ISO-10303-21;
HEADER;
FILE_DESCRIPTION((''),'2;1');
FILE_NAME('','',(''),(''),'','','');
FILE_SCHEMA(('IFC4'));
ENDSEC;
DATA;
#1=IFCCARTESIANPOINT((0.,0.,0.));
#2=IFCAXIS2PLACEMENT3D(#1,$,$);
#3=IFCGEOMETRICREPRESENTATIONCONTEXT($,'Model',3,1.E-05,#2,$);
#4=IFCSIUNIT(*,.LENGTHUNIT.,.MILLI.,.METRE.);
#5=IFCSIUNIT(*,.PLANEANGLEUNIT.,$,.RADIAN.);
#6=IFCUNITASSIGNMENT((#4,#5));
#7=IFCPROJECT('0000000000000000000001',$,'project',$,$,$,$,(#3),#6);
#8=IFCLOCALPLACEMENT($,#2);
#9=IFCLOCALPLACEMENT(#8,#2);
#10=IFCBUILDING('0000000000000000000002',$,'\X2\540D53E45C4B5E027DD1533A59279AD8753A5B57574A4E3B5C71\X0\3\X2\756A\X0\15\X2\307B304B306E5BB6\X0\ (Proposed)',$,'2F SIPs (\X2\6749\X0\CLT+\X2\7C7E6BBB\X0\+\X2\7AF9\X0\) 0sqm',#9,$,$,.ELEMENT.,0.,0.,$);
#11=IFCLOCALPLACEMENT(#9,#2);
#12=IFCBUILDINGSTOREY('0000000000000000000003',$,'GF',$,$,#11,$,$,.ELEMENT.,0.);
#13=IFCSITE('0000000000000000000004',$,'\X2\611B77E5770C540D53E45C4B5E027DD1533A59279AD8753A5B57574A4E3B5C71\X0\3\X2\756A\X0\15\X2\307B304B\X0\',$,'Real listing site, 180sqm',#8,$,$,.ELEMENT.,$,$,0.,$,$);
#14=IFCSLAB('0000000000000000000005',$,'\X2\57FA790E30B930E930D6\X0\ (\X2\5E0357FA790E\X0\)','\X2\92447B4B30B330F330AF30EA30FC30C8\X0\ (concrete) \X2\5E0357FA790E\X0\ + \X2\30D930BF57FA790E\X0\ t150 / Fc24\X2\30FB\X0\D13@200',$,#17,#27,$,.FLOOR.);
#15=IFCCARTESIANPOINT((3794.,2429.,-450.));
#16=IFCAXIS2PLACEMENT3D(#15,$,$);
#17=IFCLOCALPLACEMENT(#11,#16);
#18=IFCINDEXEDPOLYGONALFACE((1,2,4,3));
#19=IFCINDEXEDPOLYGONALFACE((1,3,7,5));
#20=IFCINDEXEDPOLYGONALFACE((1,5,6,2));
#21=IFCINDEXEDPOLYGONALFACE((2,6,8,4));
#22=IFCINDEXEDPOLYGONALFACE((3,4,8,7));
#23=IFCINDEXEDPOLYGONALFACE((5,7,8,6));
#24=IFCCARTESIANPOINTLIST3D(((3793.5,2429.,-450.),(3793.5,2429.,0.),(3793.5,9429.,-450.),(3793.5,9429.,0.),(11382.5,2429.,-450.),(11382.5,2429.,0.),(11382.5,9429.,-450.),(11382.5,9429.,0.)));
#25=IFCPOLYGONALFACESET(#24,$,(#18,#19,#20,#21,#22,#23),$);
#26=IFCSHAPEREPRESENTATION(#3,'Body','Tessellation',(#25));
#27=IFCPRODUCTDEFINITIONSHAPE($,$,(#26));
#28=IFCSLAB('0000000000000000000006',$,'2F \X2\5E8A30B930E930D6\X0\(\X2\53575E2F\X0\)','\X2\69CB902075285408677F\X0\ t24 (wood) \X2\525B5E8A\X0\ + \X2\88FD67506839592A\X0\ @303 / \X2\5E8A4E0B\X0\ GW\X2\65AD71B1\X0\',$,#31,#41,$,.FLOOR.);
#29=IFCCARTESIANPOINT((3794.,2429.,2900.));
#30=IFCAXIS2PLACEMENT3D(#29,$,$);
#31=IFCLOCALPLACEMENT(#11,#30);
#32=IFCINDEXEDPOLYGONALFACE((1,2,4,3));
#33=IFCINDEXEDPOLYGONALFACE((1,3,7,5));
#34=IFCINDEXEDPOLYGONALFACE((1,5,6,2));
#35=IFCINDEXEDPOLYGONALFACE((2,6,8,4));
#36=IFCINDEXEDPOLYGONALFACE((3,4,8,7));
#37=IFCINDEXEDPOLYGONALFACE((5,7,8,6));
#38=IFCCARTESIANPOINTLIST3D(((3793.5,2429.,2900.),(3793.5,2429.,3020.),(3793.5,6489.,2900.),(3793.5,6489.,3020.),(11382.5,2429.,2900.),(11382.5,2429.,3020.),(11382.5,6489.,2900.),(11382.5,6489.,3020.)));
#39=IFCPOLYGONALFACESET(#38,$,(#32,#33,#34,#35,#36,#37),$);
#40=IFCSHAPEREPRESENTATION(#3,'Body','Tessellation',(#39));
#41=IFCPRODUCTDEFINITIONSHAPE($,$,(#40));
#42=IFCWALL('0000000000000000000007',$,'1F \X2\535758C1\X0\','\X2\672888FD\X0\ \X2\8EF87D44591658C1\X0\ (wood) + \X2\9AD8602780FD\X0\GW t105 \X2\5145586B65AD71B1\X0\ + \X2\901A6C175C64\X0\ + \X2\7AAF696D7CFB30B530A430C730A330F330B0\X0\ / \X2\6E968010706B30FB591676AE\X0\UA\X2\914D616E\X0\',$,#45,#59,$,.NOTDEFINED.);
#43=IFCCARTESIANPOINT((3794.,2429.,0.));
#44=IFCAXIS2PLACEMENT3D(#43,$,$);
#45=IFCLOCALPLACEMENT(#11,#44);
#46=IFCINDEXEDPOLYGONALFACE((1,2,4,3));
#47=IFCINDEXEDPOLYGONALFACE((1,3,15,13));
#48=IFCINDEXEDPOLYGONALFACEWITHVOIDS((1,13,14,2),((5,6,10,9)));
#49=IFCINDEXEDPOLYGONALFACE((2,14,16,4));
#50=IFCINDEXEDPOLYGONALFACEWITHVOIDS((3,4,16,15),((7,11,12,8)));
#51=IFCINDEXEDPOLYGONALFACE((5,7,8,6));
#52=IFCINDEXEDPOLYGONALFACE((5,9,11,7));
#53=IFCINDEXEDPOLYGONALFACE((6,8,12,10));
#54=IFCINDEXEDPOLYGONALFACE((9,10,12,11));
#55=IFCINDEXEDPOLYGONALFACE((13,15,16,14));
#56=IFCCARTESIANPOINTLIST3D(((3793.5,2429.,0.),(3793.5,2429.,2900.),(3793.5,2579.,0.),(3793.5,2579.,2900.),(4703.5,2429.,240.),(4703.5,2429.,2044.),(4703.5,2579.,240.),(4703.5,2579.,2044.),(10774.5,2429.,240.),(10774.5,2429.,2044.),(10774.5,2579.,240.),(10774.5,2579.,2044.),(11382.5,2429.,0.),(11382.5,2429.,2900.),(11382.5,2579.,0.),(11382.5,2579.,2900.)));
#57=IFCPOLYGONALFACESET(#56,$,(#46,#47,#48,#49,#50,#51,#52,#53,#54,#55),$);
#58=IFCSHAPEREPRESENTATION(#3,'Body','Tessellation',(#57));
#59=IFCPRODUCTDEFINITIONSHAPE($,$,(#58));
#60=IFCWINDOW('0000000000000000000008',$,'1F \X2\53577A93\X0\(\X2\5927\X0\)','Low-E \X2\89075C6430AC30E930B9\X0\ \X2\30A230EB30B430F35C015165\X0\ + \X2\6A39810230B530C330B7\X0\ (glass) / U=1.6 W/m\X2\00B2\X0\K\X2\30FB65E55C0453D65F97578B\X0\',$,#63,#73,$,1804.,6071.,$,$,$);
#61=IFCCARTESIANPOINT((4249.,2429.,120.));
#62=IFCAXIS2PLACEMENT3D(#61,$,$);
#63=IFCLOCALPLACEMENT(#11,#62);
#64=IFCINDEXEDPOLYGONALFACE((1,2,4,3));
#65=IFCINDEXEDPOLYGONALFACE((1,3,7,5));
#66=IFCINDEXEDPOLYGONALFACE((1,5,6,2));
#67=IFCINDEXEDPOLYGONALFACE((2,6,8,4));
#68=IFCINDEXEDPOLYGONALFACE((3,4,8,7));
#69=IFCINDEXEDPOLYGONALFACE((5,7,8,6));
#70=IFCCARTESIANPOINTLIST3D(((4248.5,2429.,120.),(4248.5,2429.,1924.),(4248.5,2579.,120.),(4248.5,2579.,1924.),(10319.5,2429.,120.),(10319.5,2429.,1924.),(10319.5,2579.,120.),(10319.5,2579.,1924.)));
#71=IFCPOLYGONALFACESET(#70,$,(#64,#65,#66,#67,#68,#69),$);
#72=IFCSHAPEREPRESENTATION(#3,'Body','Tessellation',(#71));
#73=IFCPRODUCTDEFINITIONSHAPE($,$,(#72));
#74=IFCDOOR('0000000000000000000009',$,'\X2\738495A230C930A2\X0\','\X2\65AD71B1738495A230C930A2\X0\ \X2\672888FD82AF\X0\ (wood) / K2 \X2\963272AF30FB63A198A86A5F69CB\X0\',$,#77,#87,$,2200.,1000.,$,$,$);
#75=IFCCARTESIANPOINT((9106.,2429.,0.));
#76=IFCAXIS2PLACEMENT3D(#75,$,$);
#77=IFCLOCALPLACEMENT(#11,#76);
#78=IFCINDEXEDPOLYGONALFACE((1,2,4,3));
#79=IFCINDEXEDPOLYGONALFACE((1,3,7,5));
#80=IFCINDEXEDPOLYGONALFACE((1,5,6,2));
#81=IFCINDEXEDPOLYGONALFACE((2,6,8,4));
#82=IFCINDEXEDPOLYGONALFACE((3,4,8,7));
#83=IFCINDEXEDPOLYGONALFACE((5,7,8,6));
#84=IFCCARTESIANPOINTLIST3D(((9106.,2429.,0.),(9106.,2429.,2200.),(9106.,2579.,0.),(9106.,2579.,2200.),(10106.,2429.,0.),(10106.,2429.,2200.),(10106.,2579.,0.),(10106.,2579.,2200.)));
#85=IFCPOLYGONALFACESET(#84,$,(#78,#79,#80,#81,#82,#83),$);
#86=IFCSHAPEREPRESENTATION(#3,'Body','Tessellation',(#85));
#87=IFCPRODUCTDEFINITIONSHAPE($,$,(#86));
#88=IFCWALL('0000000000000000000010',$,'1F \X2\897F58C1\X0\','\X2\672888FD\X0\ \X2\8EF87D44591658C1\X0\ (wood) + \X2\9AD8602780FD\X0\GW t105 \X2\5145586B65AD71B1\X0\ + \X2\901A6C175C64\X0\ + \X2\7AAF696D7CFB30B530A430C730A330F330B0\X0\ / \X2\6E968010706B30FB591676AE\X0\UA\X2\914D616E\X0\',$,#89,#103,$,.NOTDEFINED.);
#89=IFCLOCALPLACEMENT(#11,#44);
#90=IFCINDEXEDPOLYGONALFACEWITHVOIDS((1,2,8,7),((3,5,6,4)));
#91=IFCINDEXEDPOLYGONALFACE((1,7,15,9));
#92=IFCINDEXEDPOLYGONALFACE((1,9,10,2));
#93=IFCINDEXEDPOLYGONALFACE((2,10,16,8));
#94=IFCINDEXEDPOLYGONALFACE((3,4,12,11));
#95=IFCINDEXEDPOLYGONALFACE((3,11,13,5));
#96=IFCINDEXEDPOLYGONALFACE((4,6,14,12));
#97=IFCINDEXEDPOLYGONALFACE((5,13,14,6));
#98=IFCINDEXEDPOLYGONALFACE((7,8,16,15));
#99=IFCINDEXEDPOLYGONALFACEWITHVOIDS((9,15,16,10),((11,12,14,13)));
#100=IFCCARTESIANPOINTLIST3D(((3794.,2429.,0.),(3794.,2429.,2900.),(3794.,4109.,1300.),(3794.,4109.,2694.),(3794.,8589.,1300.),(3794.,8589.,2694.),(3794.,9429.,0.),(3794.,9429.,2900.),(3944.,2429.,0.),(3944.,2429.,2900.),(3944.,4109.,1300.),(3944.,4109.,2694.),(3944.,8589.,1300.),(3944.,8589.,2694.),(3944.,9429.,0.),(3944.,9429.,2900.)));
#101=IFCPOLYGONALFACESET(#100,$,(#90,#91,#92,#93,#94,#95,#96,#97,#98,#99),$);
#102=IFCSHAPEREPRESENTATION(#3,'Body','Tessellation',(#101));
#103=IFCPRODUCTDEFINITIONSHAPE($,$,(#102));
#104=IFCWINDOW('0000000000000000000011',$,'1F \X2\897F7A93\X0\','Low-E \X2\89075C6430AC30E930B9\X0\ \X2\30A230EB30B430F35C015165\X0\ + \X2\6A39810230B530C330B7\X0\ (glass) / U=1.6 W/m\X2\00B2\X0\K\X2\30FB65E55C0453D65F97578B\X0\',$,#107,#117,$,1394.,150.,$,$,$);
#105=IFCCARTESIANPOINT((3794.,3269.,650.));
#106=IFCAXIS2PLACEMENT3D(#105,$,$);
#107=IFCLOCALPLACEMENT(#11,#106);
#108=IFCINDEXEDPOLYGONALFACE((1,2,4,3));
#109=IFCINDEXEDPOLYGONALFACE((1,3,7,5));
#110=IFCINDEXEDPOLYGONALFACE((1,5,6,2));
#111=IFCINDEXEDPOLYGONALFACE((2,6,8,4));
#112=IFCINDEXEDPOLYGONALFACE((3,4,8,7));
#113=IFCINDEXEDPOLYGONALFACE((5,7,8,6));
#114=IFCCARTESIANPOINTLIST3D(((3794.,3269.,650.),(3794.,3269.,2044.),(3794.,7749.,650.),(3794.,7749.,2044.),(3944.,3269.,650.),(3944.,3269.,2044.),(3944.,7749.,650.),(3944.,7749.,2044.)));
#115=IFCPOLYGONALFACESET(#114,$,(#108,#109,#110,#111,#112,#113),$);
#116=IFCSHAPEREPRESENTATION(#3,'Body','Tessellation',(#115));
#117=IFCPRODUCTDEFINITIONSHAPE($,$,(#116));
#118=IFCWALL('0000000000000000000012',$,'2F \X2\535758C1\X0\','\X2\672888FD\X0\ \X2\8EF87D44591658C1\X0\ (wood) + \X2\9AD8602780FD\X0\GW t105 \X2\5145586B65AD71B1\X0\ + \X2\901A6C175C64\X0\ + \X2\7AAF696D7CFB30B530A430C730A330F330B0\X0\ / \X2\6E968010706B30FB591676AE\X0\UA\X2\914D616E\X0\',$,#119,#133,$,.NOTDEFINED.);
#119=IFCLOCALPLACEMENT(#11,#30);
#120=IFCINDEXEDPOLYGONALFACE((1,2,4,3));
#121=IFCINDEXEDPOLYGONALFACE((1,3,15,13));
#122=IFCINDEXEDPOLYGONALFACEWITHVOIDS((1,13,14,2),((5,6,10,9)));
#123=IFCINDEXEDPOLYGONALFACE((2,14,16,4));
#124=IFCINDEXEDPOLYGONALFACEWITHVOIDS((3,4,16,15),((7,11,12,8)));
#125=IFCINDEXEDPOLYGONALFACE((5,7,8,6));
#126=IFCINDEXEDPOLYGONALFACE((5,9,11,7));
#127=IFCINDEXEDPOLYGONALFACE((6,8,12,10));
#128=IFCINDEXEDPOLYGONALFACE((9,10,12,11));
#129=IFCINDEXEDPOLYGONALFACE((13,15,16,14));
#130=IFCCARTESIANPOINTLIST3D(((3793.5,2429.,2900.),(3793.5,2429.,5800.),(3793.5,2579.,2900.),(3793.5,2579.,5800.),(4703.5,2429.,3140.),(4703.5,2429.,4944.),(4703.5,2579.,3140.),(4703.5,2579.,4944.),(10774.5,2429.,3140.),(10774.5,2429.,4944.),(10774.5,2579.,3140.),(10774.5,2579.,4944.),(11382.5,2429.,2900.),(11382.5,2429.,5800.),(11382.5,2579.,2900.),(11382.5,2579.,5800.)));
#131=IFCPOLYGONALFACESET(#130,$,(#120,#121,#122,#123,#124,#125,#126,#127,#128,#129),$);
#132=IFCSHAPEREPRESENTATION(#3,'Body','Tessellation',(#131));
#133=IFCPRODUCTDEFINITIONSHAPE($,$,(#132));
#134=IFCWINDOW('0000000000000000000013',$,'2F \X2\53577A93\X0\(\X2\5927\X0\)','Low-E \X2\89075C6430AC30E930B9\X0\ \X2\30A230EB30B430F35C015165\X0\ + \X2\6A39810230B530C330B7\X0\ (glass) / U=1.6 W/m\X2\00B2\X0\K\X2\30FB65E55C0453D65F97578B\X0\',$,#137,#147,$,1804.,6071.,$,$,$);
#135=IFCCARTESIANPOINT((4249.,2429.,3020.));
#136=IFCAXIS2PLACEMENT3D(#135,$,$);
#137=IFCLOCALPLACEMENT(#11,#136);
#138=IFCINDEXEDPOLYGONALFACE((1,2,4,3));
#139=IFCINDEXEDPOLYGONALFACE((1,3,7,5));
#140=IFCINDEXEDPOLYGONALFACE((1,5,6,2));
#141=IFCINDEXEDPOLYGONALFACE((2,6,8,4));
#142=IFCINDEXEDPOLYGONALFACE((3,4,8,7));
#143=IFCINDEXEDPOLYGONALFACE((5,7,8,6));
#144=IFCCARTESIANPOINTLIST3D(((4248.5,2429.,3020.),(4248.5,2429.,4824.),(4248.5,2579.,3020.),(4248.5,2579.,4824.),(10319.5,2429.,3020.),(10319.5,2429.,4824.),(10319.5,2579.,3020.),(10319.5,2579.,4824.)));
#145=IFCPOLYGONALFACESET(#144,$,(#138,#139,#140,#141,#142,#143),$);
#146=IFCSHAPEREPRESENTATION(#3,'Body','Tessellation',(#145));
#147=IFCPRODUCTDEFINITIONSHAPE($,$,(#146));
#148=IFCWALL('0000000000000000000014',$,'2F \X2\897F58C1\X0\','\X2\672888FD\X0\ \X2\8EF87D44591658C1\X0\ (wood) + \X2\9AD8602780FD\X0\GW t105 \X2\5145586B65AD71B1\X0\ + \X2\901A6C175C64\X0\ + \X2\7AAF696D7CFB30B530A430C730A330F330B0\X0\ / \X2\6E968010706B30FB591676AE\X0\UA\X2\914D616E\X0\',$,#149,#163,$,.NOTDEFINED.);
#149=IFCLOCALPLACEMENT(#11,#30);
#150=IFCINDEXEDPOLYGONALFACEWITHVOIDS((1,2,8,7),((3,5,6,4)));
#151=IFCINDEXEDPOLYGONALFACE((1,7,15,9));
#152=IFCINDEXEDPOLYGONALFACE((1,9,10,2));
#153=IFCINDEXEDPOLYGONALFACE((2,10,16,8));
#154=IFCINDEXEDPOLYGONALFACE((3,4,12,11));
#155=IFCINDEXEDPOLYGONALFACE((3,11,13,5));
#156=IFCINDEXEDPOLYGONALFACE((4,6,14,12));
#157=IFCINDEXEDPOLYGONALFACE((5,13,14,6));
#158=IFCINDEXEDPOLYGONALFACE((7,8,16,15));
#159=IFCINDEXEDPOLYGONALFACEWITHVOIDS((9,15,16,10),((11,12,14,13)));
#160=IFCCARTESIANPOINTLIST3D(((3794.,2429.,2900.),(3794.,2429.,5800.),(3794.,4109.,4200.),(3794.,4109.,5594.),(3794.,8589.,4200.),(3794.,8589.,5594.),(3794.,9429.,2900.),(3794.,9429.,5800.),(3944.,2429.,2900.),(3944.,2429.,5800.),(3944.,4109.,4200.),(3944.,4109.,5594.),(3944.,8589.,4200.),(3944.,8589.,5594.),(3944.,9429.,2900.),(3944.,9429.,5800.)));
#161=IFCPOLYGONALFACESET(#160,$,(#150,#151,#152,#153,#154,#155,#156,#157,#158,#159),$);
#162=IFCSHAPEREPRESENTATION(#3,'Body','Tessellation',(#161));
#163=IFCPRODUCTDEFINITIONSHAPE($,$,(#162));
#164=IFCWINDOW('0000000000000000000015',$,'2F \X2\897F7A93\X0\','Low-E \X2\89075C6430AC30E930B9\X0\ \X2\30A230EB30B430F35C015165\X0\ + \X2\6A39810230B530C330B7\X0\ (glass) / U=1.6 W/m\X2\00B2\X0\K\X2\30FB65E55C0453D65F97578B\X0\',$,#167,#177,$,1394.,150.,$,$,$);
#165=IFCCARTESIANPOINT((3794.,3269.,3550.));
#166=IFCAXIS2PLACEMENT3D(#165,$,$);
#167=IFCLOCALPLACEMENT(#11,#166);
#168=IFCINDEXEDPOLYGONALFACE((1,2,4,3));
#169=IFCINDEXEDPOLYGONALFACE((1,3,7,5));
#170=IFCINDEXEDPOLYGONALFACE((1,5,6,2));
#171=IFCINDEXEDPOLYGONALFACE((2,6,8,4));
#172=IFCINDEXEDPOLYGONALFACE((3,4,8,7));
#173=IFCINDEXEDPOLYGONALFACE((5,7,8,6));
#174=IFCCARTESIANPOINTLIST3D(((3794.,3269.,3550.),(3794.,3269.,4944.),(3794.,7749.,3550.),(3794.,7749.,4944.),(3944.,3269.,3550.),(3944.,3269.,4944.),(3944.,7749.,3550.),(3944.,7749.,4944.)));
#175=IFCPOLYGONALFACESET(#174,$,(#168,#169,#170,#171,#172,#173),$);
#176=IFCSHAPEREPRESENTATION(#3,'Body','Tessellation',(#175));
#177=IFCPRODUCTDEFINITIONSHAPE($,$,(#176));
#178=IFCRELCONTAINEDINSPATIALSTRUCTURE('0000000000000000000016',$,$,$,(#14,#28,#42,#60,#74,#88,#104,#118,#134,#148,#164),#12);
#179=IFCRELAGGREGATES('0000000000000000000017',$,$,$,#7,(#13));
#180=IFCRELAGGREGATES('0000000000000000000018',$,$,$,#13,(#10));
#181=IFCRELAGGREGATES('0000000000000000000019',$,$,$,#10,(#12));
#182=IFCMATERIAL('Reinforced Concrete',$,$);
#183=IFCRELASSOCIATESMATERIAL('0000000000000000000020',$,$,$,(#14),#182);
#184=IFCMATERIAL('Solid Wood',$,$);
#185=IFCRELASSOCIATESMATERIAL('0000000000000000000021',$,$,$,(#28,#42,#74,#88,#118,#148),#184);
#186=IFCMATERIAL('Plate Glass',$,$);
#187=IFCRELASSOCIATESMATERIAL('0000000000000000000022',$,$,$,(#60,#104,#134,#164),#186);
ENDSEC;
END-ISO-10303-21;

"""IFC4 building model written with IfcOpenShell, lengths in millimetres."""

from ifc_helpers import new_model, si_unit, frame, frame_2d, origin, place, context, project, spatial, rectangle, extrude, material, element, fill, save


model = new_model("IFC4")

# Units and contexts
model_context = context("Model", 3, precision=1e-05, world=origin())
ifc_project = project(units=[si_unit("LENGTHUNIT", "METRE", prefix="MILLI"), si_unit("PLANEANGLEUNIT", "RADIAN")], contexts=[model_context])

# Site, building, storey
site_placement = place(None, origin())
site = spatial("IfcSite", under=ifc_project, at=site_placement, Name="愛知県名古屋市緑区大高町字坊主山3番15ほか", ObjectType="Real listing site, 180sqm", CompositionType="ELEMENT", RefElevation=0.0)
building_placement = place(site_placement, origin())
building = spatial("IfcBuilding", under=site, at=building_placement, Name="名古屋市緑区大高町字坊主山3番15ほかの家 (Proposed)", ObjectType="2F SIPs (杉CLT+籾殻+竹) 0sqm", CompositionType="ELEMENT", ElevationOfRefHeight=0.0, ElevationOfTerrain=0.0)
storey_placement = place(building_placement, origin())
storey = spatial("IfcBuildingStorey", under=building, at=storey_placement, Name="GF", CompositionType="ELEMENT", Elevation=0.0)

# Slabs
ifc_material_1 = material(Name="Reinforced Concrete")
slab_1_placement = place(storey_placement, frame((3794.0, 2429.0, -450.0)))
element("IfcSlab", 1, at=slab_1_placement, inside=storey, material=ifc_material_1, Name="基礎スラブ (布基礎)", Description="鉄筋コンクリート (concrete) 布基礎 + ベタ基礎 t150 / Fc24・D13@200", PredefinedType="FLOOR", context=model_context, shape_type="SweptSolid", body=[
    extrude(rectangle(XDim=7589.0, YDim=7000.0, at=frame_2d((3794.0, 3500.0))), frame((3794.0, 2429.0, -450.0)), (0.0, 0.0, 1.0), 450.0),
])
ifc_material_2 = material(Name="Solid Wood")
slab_2_placement = place(storey_placement, frame((3794.0, 2429.0, 2900.0)))
element("IfcSlab", 2, at=slab_2_placement, inside=storey, material=ifc_material_2, Name="2F 床スラブ(南帯)", Description="構造用合板 t24 (wood) 剛床 + 製材根太 @303 / 床下 GW断熱", PredefinedType="FLOOR", context=model_context, shape_type="SweptSolid", body=[
    extrude(rectangle(XDim=7589.0, YDim=4060.0, at=frame_2d((3794.0, 2030.0))), frame((3794.0, 2429.0, 2900.0)), (0.0, 0.0, 1.0), 120.0),
])

# Wall, openings, window, door
wall_1_placement = place(storey_placement, frame((3794.0, 2429.0, 0.0)))
wall_1 = element("IfcWall", 3, at=wall_1_placement, inside=storey, material=ifc_material_2, Name="1F 南壁", Description="木製 軸組外壁 (wood) + 高性能GW t105 充填断熱 + 通気層 + 窯業系サイディング / 準耐火・外皮UA配慮", PredefinedType="NOTDEFINED", context=model_context, shape_type="SweptSolid", body=[
    extrude(rectangle(XDim=7589.0, YDim=150.0, at=frame_2d((3794.0, 75.0))), frame((3794.0, 2429.0, 0.0)), (0.0, 0.0, 1.0), 2900.0),
])
opening_1_placement = place(storey_placement, frame((4249.0, 2429.0, 120.0)))
opening_1 = element("IfcOpeningElement", 4, at=opening_1_placement, cuts=wall_1, PredefinedType="NOTDEFINED", context=model_context, shape_type="SweptSolid", body=[
    extrude(rectangle(XDim=6071.0, YDim=150.0, at=frame_2d((3035.0, 75.0))), frame((4249.0, 2429.0, 120.0)), (0.0, 0.0, 1.0), 1804.0),
])
opening_2_placement = place(storey_placement, frame((9106.0, 2429.0, 0.0)))
opening_2 = element("IfcOpeningElement", 5, at=opening_2_placement, cuts=wall_1, PredefinedType="NOTDEFINED", context=model_context, shape_type="SweptSolid", body=[
    extrude(rectangle(XDim=1000.0, YDim=150.0, at=frame_2d((500.0, 75.0))), frame((9106.0, 2429.0, 0.0)), (0.0, 0.0, 1.0), 2200.0),
])
ifc_material_3 = material(Name="Plate Glass")
window_1_placement = place(storey_placement, frame((4249.0, 2429.0, 120.0)))
window_1 = element("IfcWindow", 6, at=window_1_placement, inside=storey, material=ifc_material_3, Name="1F 南窓(大)", Description="Low-E 複層ガラス アルゴン封入 + 樹脂サッシ (glass) / U=1.6 W/m²K・日射取得型", OverallHeight=1804.0, OverallWidth=6071.0, context=model_context, shape_type="SweptSolid", body=[
    extrude(rectangle(XDim=6071.0, YDim=150.0, at=frame_2d((3035.0, 75.0))), frame((4249.0, 2429.0, 120.0)), (0.0, 0.0, 1.0), 1804.0),
])
fill(opening_1, window_1)
door_placement = place(storey_placement, frame((9106.0, 2429.0, 0.0)))
door = element("IfcDoor", 7, at=door_placement, inside=storey, material=ifc_material_2, Name="玄関ドア", Description="断熱玄関ドア 木製芯 (wood) / K2 防犯・採風機構", OverallHeight=2200.0, OverallWidth=1000.0, context=model_context, shape_type="SweptSolid", body=[
    extrude(rectangle(XDim=1000.0, YDim=150.0, at=frame_2d((500.0, 75.0))), frame((9106.0, 2429.0, 0.0)), (0.0, 0.0, 1.0), 2200.0),
])
fill(opening_2, door)

# Wall, opening, window
wall_2_placement = place(storey_placement, frame((3794.0, 2429.0, 0.0)))
wall_2 = element("IfcWall", 8, at=wall_2_placement, inside=storey, material=ifc_material_2, Name="1F 西壁", Description="木製 軸組外壁 (wood) + 高性能GW t105 充填断熱 + 通気層 + 窯業系サイディング / 準耐火・外皮UA配慮", PredefinedType="NOTDEFINED", context=model_context, shape_type="SweptSolid", body=[
    extrude(rectangle(XDim=150.0, YDim=7000.0, at=frame_2d((75.0, 3500.0))), frame((3794.0, 2429.0, 0.0)), (0.0, 0.0, 1.0), 2900.0),
])
opening_3_placement = place(storey_placement, frame((3794.0, 3269.0, 650.0)))
opening_3 = element("IfcOpeningElement", 9, at=opening_3_placement, cuts=wall_2, PredefinedType="NOTDEFINED", context=model_context, shape_type="SweptSolid", body=[
    extrude(rectangle(XDim=150.0, YDim=4480.0, at=frame_2d((75.0, 2240.0))), frame((3794.0, 3269.0, 650.0)), (0.0, 0.0, 1.0), 1394.0),
])
window_2_placement = place(storey_placement, frame((3794.0, 3269.0, 650.0)))
window_2 = element("IfcWindow", 10, at=window_2_placement, inside=storey, material=ifc_material_3, Name="1F 西窓", Description="Low-E 複層ガラス アルゴン封入 + 樹脂サッシ (glass) / U=1.6 W/m²K・日射取得型", OverallHeight=1394.0, OverallWidth=150.0, context=model_context, shape_type="SweptSolid", body=[
    extrude(rectangle(XDim=150.0, YDim=4480.0, at=frame_2d((75.0, 2240.0))), frame((3794.0, 3269.0, 650.0)), (0.0, 0.0, 1.0), 1394.0),
])
fill(opening_3, window_2)

# Walls, openings, windows
wall_3_placement = place(storey_placement, frame((3794.0, 2429.0, 2900.0)))
wall_3 = element("IfcWall", 11, at=wall_3_placement, inside=storey, material=ifc_material_2, Name="2F 南壁", Description="木製 軸組外壁 (wood) + 高性能GW t105 充填断熱 + 通気層 + 窯業系サイディング / 準耐火・外皮UA配慮", PredefinedType="NOTDEFINED", context=model_context, shape_type="SweptSolid", body=[
    extrude(rectangle(XDim=7589.0, YDim=150.0, at=frame_2d((3794.0, 75.0))), frame((3794.0, 2429.0, 2900.0)), (0.0, 0.0, 1.0), 2900.0),
])
opening_4_placement = place(storey_placement, frame((4249.0, 2429.0, 3020.0)))
opening_4 = element("IfcOpeningElement", 12, at=opening_4_placement, cuts=wall_3, PredefinedType="NOTDEFINED", context=model_context, shape_type="SweptSolid", body=[
    extrude(rectangle(XDim=6071.0, YDim=150.0, at=frame_2d((3035.0, 75.0))), frame((4249.0, 2429.0, 3020.0)), (0.0, 0.0, 1.0), 1804.0),
])
window_3_placement = place(storey_placement, frame((4249.0, 2429.0, 3020.0)))
window_3 = element("IfcWindow", 13, at=window_3_placement, inside=storey, material=ifc_material_3, Name="2F 南窓(大)", Description="Low-E 複層ガラス アルゴン封入 + 樹脂サッシ (glass) / U=1.6 W/m²K・日射取得型", OverallHeight=1804.0, OverallWidth=6071.0, context=model_context, shape_type="SweptSolid", body=[
    extrude(rectangle(XDim=6071.0, YDim=150.0, at=frame_2d((3035.0, 75.0))), frame((4249.0, 2429.0, 3020.0)), (0.0, 0.0, 1.0), 1804.0),
])
fill(opening_4, window_3)
wall_4_placement = place(storey_placement, frame((3794.0, 2429.0, 2900.0)))
wall_4 = element("IfcWall", 14, at=wall_4_placement, inside=storey, material=ifc_material_2, Name="2F 西壁", Description="木製 軸組外壁 (wood) + 高性能GW t105 充填断熱 + 通気層 + 窯業系サイディング / 準耐火・外皮UA配慮", PredefinedType="NOTDEFINED", context=model_context, shape_type="SweptSolid", body=[
    extrude(rectangle(XDim=150.0, YDim=7000.0, at=frame_2d((75.0, 3500.0))), frame((3794.0, 2429.0, 2900.0)), (0.0, 0.0, 1.0), 2900.0),
])
opening_5_placement = place(storey_placement, frame((3794.0, 3269.0, 3550.0)))
opening_5 = element("IfcOpeningElement", 15, at=opening_5_placement, cuts=wall_4, PredefinedType="NOTDEFINED", context=model_context, shape_type="SweptSolid", body=[
    extrude(rectangle(XDim=150.0, YDim=4480.0, at=frame_2d((75.0, 2240.0))), frame((3794.0, 3269.0, 3550.0)), (0.0, 0.0, 1.0), 1394.0),
])
window_4_placement = place(storey_placement, frame((3794.0, 3269.0, 3550.0)))
window_4 = element("IfcWindow", 16, at=window_4_placement, inside=storey, material=ifc_material_3, Name="2F 西窓", Description="Low-E 複層ガラス アルゴン封入 + 樹脂サッシ (glass) / U=1.6 W/m²K・日射取得型", OverallHeight=1394.0, OverallWidth=150.0, context=model_context, shape_type="SweptSolid", body=[
    extrude(rectangle(XDim=150.0, YDim=4480.0, at=frame_2d((75.0, 2240.0))), frame((3794.0, 3269.0, 3550.0)), (0.0, 0.0, 1.0), 1394.0),
])
fill(opening_5, window_4)

save(model, "model.ifc")
